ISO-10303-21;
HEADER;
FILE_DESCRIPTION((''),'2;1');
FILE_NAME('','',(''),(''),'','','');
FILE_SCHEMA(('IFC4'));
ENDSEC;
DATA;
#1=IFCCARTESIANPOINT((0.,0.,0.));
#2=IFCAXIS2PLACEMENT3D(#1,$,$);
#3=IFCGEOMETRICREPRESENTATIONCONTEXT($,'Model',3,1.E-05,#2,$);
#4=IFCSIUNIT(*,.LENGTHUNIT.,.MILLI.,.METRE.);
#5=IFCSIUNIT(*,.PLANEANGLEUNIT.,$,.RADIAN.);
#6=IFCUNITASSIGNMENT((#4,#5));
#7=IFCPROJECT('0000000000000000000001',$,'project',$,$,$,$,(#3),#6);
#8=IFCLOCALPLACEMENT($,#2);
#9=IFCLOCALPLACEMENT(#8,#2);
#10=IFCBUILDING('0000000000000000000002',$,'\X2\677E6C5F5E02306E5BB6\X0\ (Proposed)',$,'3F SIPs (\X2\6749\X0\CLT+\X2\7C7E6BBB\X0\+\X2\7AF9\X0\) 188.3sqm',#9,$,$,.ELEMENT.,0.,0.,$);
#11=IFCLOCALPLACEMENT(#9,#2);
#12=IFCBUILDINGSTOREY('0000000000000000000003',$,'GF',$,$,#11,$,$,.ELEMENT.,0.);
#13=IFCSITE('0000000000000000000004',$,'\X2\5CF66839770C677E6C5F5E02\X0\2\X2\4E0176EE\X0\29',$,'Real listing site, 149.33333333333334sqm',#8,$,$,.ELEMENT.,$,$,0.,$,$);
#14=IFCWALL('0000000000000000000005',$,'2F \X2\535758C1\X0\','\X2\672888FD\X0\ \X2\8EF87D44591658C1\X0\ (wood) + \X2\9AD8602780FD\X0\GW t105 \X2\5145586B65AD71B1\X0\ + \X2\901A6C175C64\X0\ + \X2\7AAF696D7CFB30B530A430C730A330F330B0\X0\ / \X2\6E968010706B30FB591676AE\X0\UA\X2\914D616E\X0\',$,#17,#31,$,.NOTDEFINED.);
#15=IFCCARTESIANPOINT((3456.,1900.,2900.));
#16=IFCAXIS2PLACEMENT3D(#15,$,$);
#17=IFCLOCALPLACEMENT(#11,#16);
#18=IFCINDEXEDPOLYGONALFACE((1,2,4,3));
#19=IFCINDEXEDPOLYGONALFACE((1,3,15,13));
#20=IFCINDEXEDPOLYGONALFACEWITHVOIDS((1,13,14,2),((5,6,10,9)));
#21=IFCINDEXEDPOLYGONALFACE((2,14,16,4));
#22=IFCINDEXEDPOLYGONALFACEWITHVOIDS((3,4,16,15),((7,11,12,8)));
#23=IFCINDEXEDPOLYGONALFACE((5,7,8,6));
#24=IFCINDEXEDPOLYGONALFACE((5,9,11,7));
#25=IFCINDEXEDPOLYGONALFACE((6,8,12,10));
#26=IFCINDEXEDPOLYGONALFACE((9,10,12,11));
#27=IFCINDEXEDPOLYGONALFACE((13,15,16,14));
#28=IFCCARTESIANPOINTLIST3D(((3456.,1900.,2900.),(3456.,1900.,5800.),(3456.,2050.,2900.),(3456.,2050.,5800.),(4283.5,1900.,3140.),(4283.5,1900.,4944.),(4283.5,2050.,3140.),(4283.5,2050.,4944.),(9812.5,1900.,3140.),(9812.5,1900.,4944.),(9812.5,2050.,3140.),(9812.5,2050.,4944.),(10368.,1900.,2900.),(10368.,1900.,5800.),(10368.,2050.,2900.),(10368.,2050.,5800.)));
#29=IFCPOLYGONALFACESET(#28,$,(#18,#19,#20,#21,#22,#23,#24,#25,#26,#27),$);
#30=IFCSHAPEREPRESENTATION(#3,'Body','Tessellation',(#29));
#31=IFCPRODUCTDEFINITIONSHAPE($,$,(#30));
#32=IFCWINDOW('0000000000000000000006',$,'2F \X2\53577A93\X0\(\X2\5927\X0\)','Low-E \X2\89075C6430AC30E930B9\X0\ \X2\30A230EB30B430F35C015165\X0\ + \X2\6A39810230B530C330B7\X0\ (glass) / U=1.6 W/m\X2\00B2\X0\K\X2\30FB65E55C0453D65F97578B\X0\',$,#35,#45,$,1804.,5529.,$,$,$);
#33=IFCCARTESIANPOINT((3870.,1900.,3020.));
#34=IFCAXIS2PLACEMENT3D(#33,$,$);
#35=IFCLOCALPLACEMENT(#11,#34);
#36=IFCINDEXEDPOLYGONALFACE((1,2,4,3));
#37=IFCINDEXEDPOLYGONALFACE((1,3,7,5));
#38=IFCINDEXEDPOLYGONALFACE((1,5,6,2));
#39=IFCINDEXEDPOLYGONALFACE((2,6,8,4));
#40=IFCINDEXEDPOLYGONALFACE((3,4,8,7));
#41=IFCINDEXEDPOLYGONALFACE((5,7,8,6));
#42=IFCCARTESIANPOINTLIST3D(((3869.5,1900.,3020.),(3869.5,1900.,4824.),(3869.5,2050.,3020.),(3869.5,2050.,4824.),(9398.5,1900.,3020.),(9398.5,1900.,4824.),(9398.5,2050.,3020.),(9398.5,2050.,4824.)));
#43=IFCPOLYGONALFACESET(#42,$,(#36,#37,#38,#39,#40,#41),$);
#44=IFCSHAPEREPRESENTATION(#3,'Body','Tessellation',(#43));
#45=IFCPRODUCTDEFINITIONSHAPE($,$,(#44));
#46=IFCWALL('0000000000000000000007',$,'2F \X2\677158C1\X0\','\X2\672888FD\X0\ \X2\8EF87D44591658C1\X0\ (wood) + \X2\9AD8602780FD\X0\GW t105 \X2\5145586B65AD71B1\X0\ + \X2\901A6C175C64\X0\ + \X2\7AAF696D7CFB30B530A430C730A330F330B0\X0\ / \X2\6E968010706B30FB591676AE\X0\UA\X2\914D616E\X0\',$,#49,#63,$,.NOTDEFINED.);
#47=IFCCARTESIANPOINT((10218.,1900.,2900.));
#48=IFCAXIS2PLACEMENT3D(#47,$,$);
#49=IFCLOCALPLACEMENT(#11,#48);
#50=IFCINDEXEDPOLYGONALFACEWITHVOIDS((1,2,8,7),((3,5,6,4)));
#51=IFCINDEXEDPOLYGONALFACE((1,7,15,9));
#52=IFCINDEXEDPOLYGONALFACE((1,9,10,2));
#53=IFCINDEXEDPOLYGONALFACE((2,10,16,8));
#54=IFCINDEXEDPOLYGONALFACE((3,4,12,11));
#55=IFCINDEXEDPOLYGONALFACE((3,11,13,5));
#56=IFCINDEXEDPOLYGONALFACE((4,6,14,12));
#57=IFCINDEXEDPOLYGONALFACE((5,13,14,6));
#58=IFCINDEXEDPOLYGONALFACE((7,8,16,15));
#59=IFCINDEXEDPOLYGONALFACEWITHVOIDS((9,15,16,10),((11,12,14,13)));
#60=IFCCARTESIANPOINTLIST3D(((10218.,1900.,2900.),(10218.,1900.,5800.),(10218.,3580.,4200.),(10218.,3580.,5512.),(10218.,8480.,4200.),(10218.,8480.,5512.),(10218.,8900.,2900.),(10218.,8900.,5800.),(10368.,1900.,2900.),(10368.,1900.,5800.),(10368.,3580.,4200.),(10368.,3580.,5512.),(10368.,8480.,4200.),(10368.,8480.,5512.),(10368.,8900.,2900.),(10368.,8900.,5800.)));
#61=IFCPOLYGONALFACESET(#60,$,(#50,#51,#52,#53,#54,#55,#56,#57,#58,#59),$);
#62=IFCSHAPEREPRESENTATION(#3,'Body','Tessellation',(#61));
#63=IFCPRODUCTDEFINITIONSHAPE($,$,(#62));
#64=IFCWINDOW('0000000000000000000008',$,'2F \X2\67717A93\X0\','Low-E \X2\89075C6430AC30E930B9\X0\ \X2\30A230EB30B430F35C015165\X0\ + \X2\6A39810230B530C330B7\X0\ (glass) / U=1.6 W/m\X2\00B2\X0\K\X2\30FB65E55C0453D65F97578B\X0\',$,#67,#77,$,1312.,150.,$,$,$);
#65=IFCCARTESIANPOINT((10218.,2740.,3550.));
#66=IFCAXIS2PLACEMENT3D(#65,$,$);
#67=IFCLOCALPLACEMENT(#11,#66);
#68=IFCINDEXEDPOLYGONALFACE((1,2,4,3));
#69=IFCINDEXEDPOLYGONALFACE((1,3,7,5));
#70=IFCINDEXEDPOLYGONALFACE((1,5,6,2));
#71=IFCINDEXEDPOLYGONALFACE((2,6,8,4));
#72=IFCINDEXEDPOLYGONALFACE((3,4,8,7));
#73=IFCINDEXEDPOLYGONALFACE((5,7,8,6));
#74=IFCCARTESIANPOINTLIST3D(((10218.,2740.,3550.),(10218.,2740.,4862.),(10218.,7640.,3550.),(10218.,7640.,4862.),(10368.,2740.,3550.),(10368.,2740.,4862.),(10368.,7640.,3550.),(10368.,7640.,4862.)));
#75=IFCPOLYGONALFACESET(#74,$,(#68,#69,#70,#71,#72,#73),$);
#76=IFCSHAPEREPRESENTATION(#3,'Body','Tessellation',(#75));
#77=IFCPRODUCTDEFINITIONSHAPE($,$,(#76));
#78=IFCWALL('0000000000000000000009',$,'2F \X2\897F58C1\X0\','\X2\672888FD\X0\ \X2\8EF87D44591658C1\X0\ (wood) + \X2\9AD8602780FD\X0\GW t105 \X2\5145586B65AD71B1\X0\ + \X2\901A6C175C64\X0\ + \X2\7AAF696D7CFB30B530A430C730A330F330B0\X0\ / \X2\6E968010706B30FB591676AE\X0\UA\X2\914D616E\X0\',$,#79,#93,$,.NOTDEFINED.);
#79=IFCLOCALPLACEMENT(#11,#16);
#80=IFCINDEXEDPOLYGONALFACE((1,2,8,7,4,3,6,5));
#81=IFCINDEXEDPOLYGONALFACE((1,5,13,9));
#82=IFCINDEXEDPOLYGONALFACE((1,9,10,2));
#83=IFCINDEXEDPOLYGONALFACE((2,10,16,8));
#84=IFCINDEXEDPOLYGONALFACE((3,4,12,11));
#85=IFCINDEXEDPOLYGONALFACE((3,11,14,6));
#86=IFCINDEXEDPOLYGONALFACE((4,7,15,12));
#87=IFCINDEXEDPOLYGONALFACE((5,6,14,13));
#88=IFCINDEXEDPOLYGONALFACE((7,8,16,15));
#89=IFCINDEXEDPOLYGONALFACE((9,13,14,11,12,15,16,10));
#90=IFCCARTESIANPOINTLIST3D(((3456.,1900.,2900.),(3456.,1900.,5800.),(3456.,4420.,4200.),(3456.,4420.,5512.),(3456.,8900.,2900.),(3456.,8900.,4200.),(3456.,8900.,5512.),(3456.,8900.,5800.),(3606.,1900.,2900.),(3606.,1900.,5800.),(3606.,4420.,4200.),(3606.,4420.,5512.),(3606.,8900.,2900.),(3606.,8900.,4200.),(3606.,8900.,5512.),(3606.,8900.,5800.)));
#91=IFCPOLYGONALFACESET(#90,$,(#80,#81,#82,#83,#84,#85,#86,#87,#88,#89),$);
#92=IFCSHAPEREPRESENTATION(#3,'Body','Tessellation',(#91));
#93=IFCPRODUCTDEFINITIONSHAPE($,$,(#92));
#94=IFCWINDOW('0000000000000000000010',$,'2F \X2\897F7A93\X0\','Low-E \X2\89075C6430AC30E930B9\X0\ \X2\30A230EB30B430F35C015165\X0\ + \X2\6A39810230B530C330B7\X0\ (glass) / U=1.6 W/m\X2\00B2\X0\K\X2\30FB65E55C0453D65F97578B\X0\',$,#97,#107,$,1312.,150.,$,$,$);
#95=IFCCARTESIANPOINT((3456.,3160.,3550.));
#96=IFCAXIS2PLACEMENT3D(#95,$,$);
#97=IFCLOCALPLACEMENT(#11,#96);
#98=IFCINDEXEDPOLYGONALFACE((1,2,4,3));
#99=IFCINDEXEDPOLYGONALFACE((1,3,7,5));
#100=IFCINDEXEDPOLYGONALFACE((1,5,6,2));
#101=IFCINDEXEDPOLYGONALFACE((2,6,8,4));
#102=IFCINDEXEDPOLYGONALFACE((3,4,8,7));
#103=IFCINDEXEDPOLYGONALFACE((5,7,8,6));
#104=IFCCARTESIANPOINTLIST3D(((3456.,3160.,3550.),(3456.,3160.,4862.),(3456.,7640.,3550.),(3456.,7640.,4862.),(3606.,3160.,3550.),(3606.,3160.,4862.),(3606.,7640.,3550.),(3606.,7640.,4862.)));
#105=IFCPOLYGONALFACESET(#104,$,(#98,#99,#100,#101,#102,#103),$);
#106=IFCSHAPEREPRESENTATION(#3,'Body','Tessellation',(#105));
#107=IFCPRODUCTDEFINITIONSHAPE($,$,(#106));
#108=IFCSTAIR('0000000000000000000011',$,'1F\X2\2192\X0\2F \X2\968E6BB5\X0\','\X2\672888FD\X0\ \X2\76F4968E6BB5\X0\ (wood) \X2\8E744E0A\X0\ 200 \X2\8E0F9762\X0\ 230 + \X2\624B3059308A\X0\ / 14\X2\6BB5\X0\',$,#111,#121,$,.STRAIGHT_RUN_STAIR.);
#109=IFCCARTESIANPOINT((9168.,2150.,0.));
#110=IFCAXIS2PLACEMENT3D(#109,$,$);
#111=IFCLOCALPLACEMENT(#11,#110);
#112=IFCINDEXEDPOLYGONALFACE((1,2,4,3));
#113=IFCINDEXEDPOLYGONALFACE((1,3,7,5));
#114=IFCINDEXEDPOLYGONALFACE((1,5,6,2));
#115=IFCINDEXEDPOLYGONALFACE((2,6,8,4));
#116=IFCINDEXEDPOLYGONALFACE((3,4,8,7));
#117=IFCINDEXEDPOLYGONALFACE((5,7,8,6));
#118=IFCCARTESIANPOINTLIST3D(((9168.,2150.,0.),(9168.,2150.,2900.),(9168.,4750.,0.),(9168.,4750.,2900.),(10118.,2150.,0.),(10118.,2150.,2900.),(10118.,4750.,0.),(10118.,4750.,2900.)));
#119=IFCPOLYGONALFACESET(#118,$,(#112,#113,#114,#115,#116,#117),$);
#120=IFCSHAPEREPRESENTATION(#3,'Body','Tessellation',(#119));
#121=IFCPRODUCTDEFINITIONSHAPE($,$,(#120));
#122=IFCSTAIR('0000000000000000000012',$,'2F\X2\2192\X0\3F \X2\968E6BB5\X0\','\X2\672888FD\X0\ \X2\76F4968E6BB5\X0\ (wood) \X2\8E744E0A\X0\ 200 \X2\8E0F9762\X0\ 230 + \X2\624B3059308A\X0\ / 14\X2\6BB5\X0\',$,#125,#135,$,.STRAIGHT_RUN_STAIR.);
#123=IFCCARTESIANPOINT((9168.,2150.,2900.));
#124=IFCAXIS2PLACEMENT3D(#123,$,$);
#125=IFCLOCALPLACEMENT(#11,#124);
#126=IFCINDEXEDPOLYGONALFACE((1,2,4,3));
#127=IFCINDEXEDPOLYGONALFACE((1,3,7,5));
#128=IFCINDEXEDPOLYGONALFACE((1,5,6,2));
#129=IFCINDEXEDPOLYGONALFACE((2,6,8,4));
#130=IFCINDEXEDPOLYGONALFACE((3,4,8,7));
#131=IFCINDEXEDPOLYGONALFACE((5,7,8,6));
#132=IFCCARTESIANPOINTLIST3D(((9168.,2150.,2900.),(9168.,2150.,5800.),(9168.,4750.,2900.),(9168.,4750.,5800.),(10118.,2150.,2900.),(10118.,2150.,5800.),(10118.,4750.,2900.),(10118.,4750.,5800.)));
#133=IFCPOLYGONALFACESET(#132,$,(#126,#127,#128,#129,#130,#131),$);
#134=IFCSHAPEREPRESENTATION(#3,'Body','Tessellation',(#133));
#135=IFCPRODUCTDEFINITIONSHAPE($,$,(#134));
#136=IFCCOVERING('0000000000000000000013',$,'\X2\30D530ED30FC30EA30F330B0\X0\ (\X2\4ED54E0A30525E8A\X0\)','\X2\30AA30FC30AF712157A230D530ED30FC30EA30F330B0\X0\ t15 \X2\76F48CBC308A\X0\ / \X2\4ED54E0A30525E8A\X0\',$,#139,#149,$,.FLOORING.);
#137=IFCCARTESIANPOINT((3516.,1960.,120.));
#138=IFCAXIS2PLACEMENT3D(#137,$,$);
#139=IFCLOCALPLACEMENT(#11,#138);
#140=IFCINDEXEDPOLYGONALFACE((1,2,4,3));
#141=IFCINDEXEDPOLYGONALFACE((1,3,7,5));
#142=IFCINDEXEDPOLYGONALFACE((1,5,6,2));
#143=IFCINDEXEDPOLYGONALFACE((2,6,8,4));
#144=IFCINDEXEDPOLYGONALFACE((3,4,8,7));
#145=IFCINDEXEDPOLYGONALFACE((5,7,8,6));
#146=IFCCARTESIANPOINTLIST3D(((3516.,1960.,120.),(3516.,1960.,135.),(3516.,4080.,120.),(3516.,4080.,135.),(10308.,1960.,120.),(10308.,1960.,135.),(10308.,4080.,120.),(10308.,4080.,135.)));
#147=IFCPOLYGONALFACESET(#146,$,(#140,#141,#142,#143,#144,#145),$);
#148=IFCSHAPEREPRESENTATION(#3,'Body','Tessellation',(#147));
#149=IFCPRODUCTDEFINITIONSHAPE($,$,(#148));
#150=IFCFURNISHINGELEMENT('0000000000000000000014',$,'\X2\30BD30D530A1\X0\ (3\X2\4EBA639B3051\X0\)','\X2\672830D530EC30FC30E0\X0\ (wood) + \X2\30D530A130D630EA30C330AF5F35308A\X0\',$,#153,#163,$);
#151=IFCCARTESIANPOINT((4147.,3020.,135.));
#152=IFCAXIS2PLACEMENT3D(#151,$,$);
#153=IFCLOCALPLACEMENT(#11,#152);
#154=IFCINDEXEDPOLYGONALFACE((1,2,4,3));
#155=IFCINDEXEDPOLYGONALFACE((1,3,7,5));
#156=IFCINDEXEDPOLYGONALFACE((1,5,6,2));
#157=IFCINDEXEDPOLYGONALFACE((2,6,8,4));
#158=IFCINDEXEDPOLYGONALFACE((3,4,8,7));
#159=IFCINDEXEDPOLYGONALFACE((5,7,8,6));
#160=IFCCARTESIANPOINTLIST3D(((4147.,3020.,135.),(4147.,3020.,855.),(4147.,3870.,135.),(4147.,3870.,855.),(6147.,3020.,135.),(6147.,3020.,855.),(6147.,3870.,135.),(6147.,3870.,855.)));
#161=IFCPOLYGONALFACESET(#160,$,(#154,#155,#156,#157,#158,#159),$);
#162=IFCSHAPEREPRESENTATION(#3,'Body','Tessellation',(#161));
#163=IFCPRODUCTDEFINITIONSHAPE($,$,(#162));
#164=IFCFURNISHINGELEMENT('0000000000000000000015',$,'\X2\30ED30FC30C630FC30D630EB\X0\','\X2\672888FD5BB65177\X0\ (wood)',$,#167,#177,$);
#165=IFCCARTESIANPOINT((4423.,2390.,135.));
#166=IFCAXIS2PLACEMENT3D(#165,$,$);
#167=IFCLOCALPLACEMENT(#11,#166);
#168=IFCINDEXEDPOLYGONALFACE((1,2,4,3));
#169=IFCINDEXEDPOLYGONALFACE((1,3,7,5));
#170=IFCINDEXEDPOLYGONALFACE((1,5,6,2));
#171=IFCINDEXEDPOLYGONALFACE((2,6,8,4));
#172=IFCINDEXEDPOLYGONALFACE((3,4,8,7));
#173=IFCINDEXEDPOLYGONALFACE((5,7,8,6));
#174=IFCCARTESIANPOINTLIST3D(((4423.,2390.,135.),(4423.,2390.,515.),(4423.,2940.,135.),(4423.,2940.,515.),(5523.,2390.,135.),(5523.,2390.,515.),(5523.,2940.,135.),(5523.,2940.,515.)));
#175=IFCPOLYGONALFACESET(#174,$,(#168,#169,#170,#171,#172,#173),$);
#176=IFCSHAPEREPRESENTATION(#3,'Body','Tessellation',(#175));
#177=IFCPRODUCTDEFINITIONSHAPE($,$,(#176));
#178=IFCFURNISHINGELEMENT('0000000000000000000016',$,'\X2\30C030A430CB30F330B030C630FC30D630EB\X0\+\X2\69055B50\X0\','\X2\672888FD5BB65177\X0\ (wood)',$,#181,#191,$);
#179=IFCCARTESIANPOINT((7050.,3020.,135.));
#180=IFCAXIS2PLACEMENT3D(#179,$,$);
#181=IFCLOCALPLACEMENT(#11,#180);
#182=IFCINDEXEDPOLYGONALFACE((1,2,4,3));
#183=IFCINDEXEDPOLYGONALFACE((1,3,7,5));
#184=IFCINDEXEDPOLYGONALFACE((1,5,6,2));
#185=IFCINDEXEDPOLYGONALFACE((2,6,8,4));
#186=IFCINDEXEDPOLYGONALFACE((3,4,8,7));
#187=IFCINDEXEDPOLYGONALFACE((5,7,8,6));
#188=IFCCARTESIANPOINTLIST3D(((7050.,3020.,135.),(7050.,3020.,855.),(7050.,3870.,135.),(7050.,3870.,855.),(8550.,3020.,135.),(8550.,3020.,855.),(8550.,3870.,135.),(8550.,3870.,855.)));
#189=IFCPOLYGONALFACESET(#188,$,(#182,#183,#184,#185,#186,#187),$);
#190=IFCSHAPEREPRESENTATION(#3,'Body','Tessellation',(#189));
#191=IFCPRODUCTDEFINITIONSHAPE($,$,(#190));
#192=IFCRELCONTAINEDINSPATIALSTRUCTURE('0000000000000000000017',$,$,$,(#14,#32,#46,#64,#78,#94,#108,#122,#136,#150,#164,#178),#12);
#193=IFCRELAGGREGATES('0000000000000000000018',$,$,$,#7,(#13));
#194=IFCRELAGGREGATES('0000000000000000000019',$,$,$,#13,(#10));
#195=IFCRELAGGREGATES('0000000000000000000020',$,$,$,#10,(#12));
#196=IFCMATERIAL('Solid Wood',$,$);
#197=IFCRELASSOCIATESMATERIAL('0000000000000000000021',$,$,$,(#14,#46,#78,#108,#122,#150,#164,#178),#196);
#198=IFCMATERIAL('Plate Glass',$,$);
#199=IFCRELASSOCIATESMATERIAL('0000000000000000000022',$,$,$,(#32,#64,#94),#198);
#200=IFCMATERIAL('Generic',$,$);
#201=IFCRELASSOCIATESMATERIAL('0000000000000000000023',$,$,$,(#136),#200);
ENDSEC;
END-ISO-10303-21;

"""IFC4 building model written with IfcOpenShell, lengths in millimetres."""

from ifc_helpers import new_model, si_unit, frame, frame_2d, origin, place, context, project, spatial, rectangle, extrude, material, element, fill, save


model = new_model("IFC4")

# Units and contexts
model_context = context("Model", 3, precision=1e-05, world=origin())
ifc_project = project(units=[si_unit("LENGTHUNIT", "METRE", prefix="MILLI"), si_unit("PLANEANGLEUNIT", "RADIAN")], contexts=[model_context])

# Site, building, storey
site_placement = place(None, origin())
site = spatial("IfcSite", under=ifc_project, at=site_placement, Name="島根県松江市2丁目29", ObjectType="Real listing site, 149.33333333333334sqm", CompositionType="ELEMENT", RefElevation=0.0)
building_placement = place(site_placement, origin())
building = spatial("IfcBuilding", under=site, at=building_placement, Name="松江市の家 (Proposed)", ObjectType="3F SIPs (杉CLT+籾殻+竹) 188.3sqm", CompositionType="ELEMENT", ElevationOfRefHeight=0.0, ElevationOfTerrain=0.0)
storey_placement = place(building_placement, origin())
storey = spatial("IfcBuildingStorey", under=building, at=storey_placement, Name="GF", CompositionType="ELEMENT", Elevation=0.0)

# Shared definitions
ifc_material_1 = material(Name="Solid Wood")
ifc_material_2 = material(Name="Generic")

# Shared definitions
ifc_material_3 = material(Name="Plate Glass")

# Walls, openings, windows
wall_1_placement = place(storey_placement, frame((3456.0, 1900.0, 2900.0)))
wall_1 = element("IfcWall", 1, at=wall_1_placement, inside=storey, material=ifc_material_1, Name="2F 南壁", Description="木製 軸組外壁 (wood) + 高性能GW t105 充填断熱 + 通気層 + 窯業系サイディング / 準耐火・外皮UA配慮", PredefinedType="NOTDEFINED", context=model_context, shape_type="SweptSolid", body=[
    extrude(rectangle(XDim=6912.0, YDim=150.0, at=frame_2d((3456.0, 75.0))), frame((3456.0, 1900.0, 2900.0)), (0.0, 0.0, 1.0), 2900.0),
])
opening_1_placement = place(storey_placement, frame((3870.0, 1900.0, 3020.0)))
opening_1 = element("IfcOpeningElement", 2, at=opening_1_placement, cuts=wall_1, PredefinedType="NOTDEFINED", context=model_context, shape_type="SweptSolid", body=[
    extrude(rectangle(XDim=5529.0, YDim=150.0, at=frame_2d((2764.0, 75.0))), frame((3870.0, 1900.0, 3020.0)), (0.0, 0.0, 1.0), 1804.0),
])
window_1_placement = place(storey_placement, frame((3870.0, 1900.0, 3020.0)))
window_1 = element("IfcWindow", 3, at=window_1_placement, inside=storey, material=ifc_material_3, Name="2F 南窓(大)", Description="Low-E 複層ガラス アルゴン封入 + 樹脂サッシ (glass) / U=1.6 W/m²K・日射取得型", OverallHeight=1804.0, OverallWidth=5529.0, context=model_context, shape_type="SweptSolid", body=[
    extrude(rectangle(XDim=5529.0, YDim=150.0, at=frame_2d((2764.0, 75.0))), frame((3870.0, 1900.0, 3020.0)), (0.0, 0.0, 1.0), 1804.0),
])
fill(opening_1, window_1)
wall_2_placement = place(storey_placement, frame((10218.0, 1900.0, 2900.0)))
wall_2 = element("IfcWall", 4, at=wall_2_placement, inside=storey, material=ifc_material_1, Name="2F 東壁", Description="木製 軸組外壁 (wood) + 高性能GW t105 充填断熱 + 通気層 + 窯業系サイディング / 準耐火・外皮UA配慮", PredefinedType="NOTDEFINED", context=model_context, shape_type="SweptSolid", body=[
    extrude(rectangle(XDim=150.0, YDim=7000.0, at=frame_2d((75.0, 3500.0))), frame((10218.0, 1900.0, 2900.0)), (0.0, 0.0, 1.0), 2900.0),
])
opening_2_placement = place(storey_placement, frame((10218.0, 2740.0, 3550.0)))
opening_2 = element("IfcOpeningElement", 5, at=opening_2_placement, cuts=wall_2, PredefinedType="NOTDEFINED", context=model_context, shape_type="SweptSolid", body=[
    extrude(rectangle(XDim=150.0, YDim=4900.0, at=frame_2d((75.0, 2450.0))), frame((10218.0, 2740.0, 3550.0)), (0.0, 0.0, 1.0), 1312.0),
])
window_2_placement = place(storey_placement, frame((10218.0, 2740.0, 3550.0)))
window_2 = element("IfcWindow", 6, at=window_2_placement, inside=storey, material=ifc_material_3, Name="2F 東窓", Description="Low-E 複層ガラス アルゴン封入 + 樹脂サッシ (glass) / U=1.6 W/m²K・日射取得型", OverallHeight=1312.0, OverallWidth=150.0, context=model_context, shape_type="SweptSolid", body=[
    extrude(rectangle(XDim=150.0, YDim=4900.0, at=frame_2d((75.0, 2450.0))), frame((10218.0, 2740.0, 3550.0)), (0.0, 0.0, 1.0), 1312.0),
])
fill(opening_2, window_2)
wall_3_placement = place(storey_placement, frame((3456.0, 1900.0, 2900.0)))
wall_3 = element("IfcWall", 7, at=wall_3_placement, inside=storey, material=ifc_material_1, Name="2F 西壁", Description="木製 軸組外壁 (wood) + 高性能GW t105 充填断熱 + 通気層 + 窯業系サイディング / 準耐火・外皮UA配慮", PredefinedType="NOTDEFINED", context=model_context, shape_type="SweptSolid", body=[
    extrude(rectangle(XDim=150.0, YDim=7000.0, at=frame_2d((75.0, 3500.0))), frame((3456.0, 1900.0, 2900.0)), (0.0, 0.0, 1.0), 2900.0),
])
opening_3_placement = place(storey_placement, frame((3456.0, 3160.0, 3550.0)))
opening_3 = element("IfcOpeningElement", 8, at=opening_3_placement, cuts=wall_3, PredefinedType="NOTDEFINED", context=model_context, shape_type="SweptSolid", body=[
    extrude(rectangle(XDim=150.0, YDim=4480.0, at=frame_2d((75.0, 2240.0))), frame((3456.0, 3160.0, 3550.0)), (0.0, 0.0, 1.0), 1312.0),
])
window_3_placement = place(storey_placement, frame((3456.0, 3160.0, 3550.0)))
window_3 = element("IfcWindow", 9, at=window_3_placement, inside=storey, material=ifc_material_3, Name="2F 西窓", Description="Low-E 複層ガラス アルゴン封入 + 樹脂サッシ (glass) / U=1.6 W/m²K・日射取得型", OverallHeight=1312.0, OverallWidth=150.0, context=model_context, shape_type="SweptSolid", body=[
    extrude(rectangle(XDim=150.0, YDim=4480.0, at=frame_2d((75.0, 2240.0))), frame((3456.0, 3160.0, 3550.0)), (0.0, 0.0, 1.0), 1312.0),
])
fill(opening_3, window_3)

# Stairs
stair_1_placement = place(storey_placement, frame((9168.0, 2150.0, 0.0)))
element("IfcStair", 10, at=stair_1_placement, inside=storey, material=ifc_material_1, Name="1F→2F 階段", Description="木製 直階段 (wood) 蹴上 200 踏面 230 + 手すり / 14段", PredefinedType="STRAIGHT_RUN_STAIR", context=model_context, shape_type="SweptSolid", body=[
    extrude(rectangle(XDim=950.0, YDim=2600.0, at=frame_2d((475.0, 1300.0))), frame((9168.0, 2150.0, 0.0)), (0.0, 0.0, 1.0), 2900.0),
])
stair_2_placement = place(storey_placement, frame((9168.0, 2150.0, 2900.0)))
element("IfcStair", 11, at=stair_2_placement, inside=storey, material=ifc_material_1, Name="2F→3F 階段", Description="木製 直階段 (wood) 蹴上 200 踏面 230 + 手すり / 14段", PredefinedType="STRAIGHT_RUN_STAIR", context=model_context, shape_type="SweptSolid", body=[
    extrude(rectangle(XDim=950.0, YDim=2600.0, at=frame_2d((475.0, 1300.0))), frame((9168.0, 2150.0, 2900.0)), (0.0, 0.0, 1.0), 2900.0),
])

# Covering
covering_placement = place(storey_placement, frame((3516.0, 1960.0, 120.0)))
element("IfcCovering", 12, at=covering_placement, inside=storey, material=ifc_material_2, Name="フローリング (仕上げ床)", Description="オーク無垢フローリング t15 直貼り / 仕上げ床", PredefinedType="FLOORING", context=model_context, shape_type="SweptSolid", body=[
    extrude(rectangle(XDim=6792.0, YDim=2120.0, at=frame_2d((3396.0, 1060.0))), frame((3516.0, 1960.0, 120.0)), (0.0, 0.0, 1.0), 15.0),
])

# Furnishing elements
furnishing_1_placement = place(storey_placement, frame((4147.0, 3020.0, 135.0)))
element("IfcFurnishingElement", 13, at=furnishing_1_placement, inside=storey, material=ifc_material_1, Name="ソファ (3人掛け)", Description="木フレーム (wood) + ファブリック張り", context=model_context, shape_type="SweptSolid", body=[
    extrude(rectangle(XDim=2000.0, YDim=850.0, at=frame_2d((1000.0, 425.0))), frame((4147.0, 3020.0, 135.0)), (0.0, 0.0, 1.0), 720.0),
])
furnishing_2_placement = place(storey_placement, frame((4423.0, 2390.0, 135.0)))
element("IfcFurnishingElement", 14, at=furnishing_2_placement, inside=storey, material=ifc_material_1, Name="ローテーブル", Description="木製家具 (wood)", context=model_context, shape_type="SweptSolid", body=[
    extrude(rectangle(XDim=1100.0, YDim=550.0, at=frame_2d((550.0, 275.0))), frame((4423.0, 2390.0, 135.0)), (0.0, 0.0, 1.0), 380.0),
])
furnishing_3_placement = place(storey_placement, frame((7050.0, 3020.0, 135.0)))
element("IfcFurnishingElement", 15, at=furnishing_3_placement, inside=storey, material=ifc_material_1, Name="ダイニングテーブル+椅子", Description="木製家具 (wood)", context=model_context, shape_type="SweptSolid", body=[
    extrude(rectangle(XDim=1500.0, YDim=850.0, at=frame_2d((750.0, 425.0))), frame((7050.0, 3020.0, 135.0)), (0.0, 0.0, 1.0), 720.0),
])

save(model, "model.ifc")
